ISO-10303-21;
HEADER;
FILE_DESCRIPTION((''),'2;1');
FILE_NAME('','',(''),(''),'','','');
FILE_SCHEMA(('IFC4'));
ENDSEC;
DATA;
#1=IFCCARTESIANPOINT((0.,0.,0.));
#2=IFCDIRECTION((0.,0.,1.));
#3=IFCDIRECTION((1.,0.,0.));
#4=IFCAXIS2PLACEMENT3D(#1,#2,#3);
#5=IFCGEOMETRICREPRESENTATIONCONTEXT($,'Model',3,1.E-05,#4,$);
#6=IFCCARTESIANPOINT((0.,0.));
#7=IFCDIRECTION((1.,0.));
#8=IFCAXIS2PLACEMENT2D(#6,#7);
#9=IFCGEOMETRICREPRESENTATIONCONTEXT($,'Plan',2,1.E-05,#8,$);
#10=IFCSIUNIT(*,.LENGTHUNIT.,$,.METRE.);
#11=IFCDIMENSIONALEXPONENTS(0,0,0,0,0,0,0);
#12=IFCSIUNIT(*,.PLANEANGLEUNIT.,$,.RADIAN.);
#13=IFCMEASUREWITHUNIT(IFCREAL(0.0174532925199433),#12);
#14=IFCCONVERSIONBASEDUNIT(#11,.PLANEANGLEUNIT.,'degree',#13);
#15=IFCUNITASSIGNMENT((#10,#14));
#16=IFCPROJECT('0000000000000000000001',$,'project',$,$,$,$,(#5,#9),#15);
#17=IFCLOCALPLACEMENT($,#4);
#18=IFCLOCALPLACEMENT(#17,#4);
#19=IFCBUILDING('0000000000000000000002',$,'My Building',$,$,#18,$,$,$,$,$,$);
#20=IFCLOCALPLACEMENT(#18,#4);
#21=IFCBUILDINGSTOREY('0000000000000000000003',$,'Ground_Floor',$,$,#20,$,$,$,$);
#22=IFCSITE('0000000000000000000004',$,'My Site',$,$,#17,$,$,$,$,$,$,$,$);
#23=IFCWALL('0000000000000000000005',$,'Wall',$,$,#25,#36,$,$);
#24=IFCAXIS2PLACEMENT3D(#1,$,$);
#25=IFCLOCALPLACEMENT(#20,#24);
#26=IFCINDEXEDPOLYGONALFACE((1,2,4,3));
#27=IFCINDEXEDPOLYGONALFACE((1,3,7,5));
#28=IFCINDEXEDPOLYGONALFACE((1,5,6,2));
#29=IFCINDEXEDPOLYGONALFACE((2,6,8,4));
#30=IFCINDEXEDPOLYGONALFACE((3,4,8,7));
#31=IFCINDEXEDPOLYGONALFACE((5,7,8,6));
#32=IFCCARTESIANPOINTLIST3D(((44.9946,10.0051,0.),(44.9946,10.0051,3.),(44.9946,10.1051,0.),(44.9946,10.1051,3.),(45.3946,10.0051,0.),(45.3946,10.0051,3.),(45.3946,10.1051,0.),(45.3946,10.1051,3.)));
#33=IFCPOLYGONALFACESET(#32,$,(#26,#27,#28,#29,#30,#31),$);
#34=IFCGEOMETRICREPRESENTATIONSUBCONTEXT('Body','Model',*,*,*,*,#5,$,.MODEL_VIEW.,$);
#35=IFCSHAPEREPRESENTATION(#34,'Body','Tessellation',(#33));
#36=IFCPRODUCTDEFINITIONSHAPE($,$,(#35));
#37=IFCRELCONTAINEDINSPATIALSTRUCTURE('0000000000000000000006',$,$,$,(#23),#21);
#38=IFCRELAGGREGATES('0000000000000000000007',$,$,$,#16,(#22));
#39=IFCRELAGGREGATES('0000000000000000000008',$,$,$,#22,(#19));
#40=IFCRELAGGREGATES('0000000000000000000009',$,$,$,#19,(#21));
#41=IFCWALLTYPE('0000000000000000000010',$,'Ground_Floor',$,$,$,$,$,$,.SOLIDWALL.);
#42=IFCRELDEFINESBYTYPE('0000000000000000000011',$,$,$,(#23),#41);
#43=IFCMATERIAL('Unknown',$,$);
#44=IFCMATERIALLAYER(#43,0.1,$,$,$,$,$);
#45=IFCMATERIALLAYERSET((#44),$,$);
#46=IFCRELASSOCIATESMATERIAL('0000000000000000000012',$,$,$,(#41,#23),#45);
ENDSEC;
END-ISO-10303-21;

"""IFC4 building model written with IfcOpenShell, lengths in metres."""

from ifc_helpers import new_model, entity, si_unit, converted_unit, frame, origin_with_axes, origin_2d_with_axis, place, context, subcontext, project, spatial, line, indexed_curve, outline, extrude, material, layer, layer_set, layer_usage, type_object, element, save


model = new_model("IFC4")

# Units and contexts
model_context = context("Model", 3, precision=1e-05, world=origin_with_axes())
plan_context = context("Plan", 2, precision=1e-05, world=origin_2d_with_axis())
body_context_1 = subcontext(model_context, "Body", "Model", "MODEL_VIEW")
ifc_project = project(units=[si_unit("LENGTHUNIT", "METRE"), converted_unit("PLANEANGLEUNIT", "degree", entity("IfcReal", 0.0174532925199433), si_unit("PLANEANGLEUNIT", "RADIAN"), dimensions=[0, 0, 0, 0, 0, 0, 0])], contexts=[model_context, plan_context])

# Site, building, storey
site_placement = place(None, origin_with_axes())
site = spatial("IfcSite", under=ifc_project, at=site_placement, Name="My Site")
building_placement = place(site_placement, origin_with_axes())
building = spatial("IfcBuilding", under=site, at=building_placement, Name="My Building")
storey_placement = place(building_placement, origin_with_axes())
storey = spatial("IfcBuildingStorey", under=building, at=storey_placement, Name="Ground_Floor")

# Shared definitions
ifc_material = material(Name="Unknown")

# Shared definitions
ifc_layer = layer(ifc_material, 0.1)
ifc_layer_set = layer_set([ifc_layer])
wall_type = type_object("IfcWallType", Name="Ground_Floor", PredefinedType="SOLIDWALL", material=ifc_layer_set)

# Wall
ifc_layer_usage_1 = layer_usage(ifc_layer_set, "AXIS2", "POSITIVE", 0.0)
wall_1_placement = place(storey_placement, frame((44.9946, 10.0051, 0.0), z_axis=(0.0, 0.0, 1.0), x_axis=(1.0, 0.0, 0.0)))
element("IfcWall", 1, at=wall_1_placement, inside=storey, type_object=wall_type, material=ifc_layer_usage_1, Name="Wall", context=body_context_1, shape_type="SweptSolid", body=[
    extrude(outline(indexed_curve([(0.0, 0.0), (0.0, 0.1), (0.4, 0.1), (0.4, 0.0)], segments=[line(1, 2, 3, 4, 1)])), origin_with_axes(), (0.0, 0.0, 1.0), 3.0),
])

save(model, "model.ifc")
